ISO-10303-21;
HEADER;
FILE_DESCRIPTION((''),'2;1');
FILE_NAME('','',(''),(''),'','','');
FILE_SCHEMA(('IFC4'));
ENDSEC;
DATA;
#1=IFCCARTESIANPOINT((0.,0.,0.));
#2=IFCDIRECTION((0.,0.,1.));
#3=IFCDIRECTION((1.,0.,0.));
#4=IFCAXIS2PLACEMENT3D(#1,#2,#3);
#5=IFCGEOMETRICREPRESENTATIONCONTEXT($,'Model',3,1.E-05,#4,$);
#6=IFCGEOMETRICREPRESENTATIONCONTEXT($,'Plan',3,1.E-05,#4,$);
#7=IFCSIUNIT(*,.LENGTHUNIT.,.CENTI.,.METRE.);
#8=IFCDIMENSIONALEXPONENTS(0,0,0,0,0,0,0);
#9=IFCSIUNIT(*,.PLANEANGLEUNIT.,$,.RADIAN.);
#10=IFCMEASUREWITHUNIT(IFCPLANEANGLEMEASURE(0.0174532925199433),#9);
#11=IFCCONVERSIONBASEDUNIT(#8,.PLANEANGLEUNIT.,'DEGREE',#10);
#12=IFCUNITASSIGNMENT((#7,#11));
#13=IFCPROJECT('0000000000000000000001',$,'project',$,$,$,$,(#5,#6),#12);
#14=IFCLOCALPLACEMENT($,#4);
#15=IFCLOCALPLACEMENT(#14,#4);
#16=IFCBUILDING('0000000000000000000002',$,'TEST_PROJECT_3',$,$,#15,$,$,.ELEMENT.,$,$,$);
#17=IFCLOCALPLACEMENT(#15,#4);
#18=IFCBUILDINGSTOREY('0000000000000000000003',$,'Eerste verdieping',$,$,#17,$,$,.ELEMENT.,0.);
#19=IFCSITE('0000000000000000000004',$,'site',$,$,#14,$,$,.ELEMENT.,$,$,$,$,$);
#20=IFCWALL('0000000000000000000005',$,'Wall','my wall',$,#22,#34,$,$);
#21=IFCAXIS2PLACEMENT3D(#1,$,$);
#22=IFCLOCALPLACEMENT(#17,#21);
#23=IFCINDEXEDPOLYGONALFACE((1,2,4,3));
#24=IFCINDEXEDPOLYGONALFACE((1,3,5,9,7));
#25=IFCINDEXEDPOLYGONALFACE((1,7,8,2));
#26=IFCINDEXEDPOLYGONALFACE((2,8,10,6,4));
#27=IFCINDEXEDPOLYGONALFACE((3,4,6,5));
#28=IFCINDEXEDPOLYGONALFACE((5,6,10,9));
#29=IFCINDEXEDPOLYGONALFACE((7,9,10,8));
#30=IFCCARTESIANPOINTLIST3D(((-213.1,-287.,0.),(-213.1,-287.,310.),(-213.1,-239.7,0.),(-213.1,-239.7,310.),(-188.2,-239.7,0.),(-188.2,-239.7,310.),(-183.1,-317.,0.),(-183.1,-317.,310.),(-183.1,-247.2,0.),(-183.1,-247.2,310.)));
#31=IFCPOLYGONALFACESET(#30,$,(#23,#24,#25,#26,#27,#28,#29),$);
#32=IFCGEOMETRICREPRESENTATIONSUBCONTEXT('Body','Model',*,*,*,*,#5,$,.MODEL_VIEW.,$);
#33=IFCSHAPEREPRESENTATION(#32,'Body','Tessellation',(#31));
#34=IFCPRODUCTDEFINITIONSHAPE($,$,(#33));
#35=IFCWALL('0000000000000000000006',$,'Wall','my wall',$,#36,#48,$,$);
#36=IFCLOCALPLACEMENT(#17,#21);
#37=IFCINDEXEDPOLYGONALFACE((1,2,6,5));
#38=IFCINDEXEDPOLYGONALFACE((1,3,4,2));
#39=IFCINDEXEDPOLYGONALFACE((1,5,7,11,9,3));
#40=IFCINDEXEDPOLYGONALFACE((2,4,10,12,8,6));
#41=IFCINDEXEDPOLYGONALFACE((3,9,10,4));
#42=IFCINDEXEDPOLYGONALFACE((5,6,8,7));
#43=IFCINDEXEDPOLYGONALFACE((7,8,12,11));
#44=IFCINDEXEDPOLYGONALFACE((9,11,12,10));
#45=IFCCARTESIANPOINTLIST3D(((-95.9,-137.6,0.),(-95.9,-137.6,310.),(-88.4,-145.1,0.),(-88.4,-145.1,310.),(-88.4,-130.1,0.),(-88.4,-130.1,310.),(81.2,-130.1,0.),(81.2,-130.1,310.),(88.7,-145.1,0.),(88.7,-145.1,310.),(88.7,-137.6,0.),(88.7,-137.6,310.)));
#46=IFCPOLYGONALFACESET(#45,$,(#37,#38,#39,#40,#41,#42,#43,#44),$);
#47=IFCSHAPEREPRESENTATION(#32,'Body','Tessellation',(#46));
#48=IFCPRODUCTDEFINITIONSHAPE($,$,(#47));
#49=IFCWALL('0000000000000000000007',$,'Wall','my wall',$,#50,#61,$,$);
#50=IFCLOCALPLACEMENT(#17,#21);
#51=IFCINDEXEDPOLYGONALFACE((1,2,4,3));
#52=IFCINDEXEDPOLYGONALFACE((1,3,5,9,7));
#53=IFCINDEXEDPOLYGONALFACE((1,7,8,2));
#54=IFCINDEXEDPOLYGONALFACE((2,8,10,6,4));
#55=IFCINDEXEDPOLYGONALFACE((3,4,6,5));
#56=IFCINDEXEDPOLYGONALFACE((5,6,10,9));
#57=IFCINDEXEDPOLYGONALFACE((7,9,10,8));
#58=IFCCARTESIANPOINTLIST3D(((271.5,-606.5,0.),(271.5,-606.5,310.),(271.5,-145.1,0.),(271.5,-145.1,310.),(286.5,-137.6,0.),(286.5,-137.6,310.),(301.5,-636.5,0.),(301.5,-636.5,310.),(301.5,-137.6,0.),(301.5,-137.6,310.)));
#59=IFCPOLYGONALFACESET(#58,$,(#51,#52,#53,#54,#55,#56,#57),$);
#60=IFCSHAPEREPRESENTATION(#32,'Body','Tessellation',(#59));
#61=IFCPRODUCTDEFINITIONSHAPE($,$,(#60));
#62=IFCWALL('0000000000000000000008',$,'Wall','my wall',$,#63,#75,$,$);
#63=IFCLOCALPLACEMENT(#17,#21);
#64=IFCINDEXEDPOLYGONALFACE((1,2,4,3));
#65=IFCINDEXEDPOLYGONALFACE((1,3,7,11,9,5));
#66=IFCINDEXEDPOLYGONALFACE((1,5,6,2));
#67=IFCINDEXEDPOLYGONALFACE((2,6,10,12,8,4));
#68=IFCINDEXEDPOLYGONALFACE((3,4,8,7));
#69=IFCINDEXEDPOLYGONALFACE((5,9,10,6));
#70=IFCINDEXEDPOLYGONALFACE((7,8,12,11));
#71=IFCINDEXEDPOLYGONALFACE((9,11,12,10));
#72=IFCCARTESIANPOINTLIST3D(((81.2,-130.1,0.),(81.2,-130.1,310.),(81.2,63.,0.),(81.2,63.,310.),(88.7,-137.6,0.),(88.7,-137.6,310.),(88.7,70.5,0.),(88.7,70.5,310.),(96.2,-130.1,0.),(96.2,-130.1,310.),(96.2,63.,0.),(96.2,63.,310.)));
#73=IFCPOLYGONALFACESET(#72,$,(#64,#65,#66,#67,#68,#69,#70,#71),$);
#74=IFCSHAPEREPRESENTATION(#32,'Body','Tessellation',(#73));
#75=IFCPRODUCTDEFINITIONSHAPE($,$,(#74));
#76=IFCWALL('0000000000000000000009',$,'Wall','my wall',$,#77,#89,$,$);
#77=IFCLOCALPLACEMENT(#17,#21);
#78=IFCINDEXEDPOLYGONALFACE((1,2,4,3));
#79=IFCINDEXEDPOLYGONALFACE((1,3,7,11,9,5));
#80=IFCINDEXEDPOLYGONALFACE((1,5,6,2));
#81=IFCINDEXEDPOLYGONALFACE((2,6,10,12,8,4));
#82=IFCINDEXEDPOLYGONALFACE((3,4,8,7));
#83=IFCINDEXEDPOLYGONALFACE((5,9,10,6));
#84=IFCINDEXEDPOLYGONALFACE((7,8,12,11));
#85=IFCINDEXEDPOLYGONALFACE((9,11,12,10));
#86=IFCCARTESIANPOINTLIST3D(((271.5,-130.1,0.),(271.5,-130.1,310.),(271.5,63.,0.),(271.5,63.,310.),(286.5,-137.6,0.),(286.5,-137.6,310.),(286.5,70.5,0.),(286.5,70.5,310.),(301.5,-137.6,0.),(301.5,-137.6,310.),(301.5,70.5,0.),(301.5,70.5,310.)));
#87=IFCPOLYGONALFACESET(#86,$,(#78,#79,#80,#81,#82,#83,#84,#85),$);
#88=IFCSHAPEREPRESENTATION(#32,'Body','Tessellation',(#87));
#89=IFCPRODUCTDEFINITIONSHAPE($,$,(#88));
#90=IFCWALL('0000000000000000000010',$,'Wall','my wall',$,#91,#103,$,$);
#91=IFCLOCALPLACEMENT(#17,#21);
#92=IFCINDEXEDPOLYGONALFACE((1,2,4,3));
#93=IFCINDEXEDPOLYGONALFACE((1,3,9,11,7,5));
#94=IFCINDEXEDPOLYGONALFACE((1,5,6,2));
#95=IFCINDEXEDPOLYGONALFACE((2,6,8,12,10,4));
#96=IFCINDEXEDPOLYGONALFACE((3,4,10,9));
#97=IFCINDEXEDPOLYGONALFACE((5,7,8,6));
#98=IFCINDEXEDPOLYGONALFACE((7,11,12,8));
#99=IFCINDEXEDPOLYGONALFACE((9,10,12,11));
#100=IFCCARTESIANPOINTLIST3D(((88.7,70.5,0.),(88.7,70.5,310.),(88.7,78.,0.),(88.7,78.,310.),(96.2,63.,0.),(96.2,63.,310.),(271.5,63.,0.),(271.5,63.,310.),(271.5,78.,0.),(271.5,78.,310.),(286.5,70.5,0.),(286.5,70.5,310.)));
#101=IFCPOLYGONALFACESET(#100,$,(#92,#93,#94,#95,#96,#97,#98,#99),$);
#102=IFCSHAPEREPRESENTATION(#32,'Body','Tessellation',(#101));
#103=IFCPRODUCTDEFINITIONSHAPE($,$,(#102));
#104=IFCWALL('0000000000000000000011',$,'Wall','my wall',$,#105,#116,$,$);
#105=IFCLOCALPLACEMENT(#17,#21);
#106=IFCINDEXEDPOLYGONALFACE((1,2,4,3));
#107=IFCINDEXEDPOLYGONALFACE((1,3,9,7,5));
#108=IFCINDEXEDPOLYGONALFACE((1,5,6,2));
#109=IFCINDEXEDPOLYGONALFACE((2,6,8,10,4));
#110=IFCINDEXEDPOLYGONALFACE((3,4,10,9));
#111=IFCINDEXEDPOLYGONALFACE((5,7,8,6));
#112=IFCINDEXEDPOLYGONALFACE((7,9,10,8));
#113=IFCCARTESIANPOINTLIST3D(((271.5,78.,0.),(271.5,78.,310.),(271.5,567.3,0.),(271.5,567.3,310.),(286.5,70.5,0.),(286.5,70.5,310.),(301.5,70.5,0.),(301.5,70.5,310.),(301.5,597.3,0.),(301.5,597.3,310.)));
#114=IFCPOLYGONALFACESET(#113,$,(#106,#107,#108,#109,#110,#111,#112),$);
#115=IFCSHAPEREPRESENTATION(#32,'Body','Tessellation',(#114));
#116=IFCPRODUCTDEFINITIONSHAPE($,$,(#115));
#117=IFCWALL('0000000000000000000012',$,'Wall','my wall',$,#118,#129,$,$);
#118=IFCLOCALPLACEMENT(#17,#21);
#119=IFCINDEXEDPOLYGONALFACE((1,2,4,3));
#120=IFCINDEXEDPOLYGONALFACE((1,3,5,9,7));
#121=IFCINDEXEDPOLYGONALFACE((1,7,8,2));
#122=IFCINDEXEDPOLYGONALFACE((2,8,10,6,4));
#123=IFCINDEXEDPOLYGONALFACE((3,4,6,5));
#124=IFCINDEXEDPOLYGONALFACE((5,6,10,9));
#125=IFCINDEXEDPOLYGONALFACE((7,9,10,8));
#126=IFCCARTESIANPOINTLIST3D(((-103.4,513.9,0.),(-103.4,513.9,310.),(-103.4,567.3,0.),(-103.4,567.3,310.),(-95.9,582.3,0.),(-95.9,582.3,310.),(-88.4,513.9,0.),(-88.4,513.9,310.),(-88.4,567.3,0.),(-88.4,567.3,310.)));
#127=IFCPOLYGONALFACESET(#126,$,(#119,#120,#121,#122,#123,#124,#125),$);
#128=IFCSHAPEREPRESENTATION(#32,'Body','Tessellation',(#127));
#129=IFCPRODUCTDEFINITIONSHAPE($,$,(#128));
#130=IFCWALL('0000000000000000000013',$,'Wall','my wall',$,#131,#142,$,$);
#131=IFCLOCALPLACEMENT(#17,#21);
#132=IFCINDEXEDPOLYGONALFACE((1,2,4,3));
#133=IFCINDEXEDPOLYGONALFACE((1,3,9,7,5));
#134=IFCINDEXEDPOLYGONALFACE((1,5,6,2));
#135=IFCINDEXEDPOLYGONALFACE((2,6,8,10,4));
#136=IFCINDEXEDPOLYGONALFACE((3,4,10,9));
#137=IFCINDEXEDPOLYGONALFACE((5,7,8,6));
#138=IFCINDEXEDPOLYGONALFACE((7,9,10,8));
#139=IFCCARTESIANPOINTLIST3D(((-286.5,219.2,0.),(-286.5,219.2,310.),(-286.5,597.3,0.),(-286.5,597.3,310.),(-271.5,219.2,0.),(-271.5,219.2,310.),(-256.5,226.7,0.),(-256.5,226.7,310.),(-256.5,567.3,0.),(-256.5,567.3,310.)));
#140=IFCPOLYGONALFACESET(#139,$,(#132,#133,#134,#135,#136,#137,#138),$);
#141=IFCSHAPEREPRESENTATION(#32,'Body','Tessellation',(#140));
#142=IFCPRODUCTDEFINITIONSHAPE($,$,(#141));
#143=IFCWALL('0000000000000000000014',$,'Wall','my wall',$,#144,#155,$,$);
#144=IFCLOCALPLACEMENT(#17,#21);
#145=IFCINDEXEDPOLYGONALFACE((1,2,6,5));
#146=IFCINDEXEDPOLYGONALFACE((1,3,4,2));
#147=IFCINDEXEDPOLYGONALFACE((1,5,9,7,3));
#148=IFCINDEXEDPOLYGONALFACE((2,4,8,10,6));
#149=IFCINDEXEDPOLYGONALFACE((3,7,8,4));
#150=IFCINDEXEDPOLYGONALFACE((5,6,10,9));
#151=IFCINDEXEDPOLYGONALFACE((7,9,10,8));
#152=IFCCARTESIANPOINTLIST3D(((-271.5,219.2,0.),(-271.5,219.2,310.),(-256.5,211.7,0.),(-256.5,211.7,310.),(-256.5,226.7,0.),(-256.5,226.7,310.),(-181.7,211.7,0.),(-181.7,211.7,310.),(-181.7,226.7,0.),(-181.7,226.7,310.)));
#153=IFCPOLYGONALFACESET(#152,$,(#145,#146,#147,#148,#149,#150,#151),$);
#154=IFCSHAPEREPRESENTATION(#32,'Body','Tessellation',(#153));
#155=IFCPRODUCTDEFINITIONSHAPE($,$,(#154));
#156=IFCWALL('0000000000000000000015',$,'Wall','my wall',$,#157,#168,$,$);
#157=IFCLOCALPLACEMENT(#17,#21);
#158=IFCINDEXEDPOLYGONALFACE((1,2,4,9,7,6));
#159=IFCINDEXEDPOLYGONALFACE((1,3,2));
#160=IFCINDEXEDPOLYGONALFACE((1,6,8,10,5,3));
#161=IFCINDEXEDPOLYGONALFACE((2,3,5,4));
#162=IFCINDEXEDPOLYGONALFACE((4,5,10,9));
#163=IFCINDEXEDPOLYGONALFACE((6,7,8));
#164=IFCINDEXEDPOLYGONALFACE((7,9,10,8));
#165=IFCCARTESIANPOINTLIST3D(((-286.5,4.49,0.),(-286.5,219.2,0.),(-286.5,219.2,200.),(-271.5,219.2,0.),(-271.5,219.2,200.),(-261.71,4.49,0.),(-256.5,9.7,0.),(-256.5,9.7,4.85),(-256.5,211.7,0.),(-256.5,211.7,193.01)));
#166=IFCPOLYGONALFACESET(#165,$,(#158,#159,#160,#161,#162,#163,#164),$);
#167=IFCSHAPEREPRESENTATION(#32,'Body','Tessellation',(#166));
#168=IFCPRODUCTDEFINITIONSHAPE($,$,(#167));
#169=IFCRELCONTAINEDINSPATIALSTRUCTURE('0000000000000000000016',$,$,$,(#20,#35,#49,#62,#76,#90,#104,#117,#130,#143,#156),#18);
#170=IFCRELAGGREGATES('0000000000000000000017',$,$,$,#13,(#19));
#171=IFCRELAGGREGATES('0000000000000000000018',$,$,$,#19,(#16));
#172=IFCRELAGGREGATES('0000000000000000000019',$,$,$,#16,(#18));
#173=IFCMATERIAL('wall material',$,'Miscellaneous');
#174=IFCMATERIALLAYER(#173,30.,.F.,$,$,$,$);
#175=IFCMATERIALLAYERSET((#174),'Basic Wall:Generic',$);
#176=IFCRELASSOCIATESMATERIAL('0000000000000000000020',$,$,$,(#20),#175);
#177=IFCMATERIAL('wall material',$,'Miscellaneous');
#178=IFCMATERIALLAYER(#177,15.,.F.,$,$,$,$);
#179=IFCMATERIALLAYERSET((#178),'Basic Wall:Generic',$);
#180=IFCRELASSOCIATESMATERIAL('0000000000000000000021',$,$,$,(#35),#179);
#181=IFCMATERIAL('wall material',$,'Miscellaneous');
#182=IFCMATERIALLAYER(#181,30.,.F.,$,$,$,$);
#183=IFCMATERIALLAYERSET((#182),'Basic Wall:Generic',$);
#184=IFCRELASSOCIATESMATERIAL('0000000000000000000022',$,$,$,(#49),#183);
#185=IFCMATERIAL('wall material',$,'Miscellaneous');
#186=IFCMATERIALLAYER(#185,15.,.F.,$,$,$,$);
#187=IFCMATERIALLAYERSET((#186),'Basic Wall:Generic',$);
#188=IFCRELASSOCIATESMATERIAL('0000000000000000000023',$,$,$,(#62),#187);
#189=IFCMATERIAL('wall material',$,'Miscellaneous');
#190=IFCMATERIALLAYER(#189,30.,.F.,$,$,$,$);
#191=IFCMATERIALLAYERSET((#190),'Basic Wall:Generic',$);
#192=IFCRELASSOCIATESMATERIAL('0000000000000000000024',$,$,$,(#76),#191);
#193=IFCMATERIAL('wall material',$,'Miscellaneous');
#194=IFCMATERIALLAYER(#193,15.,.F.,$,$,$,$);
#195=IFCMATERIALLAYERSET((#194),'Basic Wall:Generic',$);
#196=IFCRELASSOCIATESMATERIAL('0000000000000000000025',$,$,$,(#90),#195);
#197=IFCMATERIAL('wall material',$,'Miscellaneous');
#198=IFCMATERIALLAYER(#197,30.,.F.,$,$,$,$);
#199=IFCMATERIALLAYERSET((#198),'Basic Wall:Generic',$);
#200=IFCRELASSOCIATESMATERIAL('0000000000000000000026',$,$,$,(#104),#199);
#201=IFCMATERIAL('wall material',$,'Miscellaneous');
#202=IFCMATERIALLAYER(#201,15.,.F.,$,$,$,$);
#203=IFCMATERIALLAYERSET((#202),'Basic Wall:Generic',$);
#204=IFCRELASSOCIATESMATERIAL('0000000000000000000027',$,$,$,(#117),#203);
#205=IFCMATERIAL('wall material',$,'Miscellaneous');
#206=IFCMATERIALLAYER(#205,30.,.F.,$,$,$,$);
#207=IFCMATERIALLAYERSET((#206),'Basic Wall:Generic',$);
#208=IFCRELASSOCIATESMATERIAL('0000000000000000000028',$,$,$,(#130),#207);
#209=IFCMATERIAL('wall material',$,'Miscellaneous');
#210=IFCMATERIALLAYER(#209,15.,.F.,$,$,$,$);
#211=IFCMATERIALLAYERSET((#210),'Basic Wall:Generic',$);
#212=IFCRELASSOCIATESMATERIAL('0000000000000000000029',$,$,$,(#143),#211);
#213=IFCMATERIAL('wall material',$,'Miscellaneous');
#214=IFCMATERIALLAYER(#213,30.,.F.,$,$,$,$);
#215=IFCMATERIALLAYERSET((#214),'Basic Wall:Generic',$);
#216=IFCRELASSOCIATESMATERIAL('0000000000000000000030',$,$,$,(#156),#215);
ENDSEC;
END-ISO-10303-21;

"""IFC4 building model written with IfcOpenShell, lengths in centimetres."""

from ifc_helpers import new_model, entity, si_unit, converted_unit, frame, origin_with_axes, place, context, subcontext, project, spatial, polyline, outline, extrude, clip, bounded_halfspace, material, layer, layer_set, layer_usage, element, save


model = new_model("IFC4")

# Units and contexts
model_context = context("Model", 3, precision=1e-05, world=origin_with_axes())
plan_context = context("Plan", 3, precision=1e-05, world=origin_with_axes())
body_context = subcontext(model_context, "Body", "Model", "MODEL_VIEW")
ifc_project = project(units=[si_unit("LENGTHUNIT", "METRE", prefix="CENTI"), converted_unit("PLANEANGLEUNIT", "DEGREE", entity("IfcPlaneAngleMeasure", 0.0174532925199433), si_unit("PLANEANGLEUNIT", "RADIAN"), dimensions=[0, 0, 0, 0, 0, 0, 0])], contexts=[model_context, plan_context])

# Site, building, storey
site_placement = place(None, origin_with_axes())
site = spatial("IfcSite", under=ifc_project, at=site_placement, Name="site", CompositionType="ELEMENT")
building_placement = place(site_placement, origin_with_axes())
building = spatial("IfcBuilding", under=site, at=building_placement, Name="TEST_PROJECT_3", CompositionType="ELEMENT")
storey_placement = place(building_placement, origin_with_axes())
storey = spatial("IfcBuildingStorey", under=building, at=storey_placement, Name="Eerste verdieping", CompositionType="ELEMENT", Elevation=0.0)

# Walls
ifc_material_1 = material(Name="wall material", Category="Miscellaneous")
ifc_layer_1 = layer(ifc_material_1, 30.0, ventilated=False)
ifc_layer_set_1 = layer_set([ifc_layer_1], Name="Basic Wall:Generic")
ifc_layer_usage_1 = layer_usage(ifc_layer_set_1, "AXIS3", "NEGATIVE", 0.0)
wall_1_placement = place(storey_placement, origin_with_axes())
element("IfcWall", 1, at=wall_1_placement, inside=storey, material=ifc_layer_usage_1, Name="Wall", Description="my wall", context=body_context, shape_type="SweptSolid", body=[
    extrude(outline(polyline([(-213.1, -287.0, 0.0), (-213.1, -239.7, 0.0), (-188.2, -239.7, 0.0), (-183.1, -247.2, 0.0), (-183.1, -317.0, 0.0), (-213.1, -287.0, 0.0)])), origin_with_axes(), (0.0, 0.0, 1.0), 310.0),
])
ifc_material_2 = material(Name="wall material", Category="Miscellaneous")
ifc_layer_2 = layer(ifc_material_2, 15.0, ventilated=False)
ifc_layer_set_2 = layer_set([ifc_layer_2], Name="Basic Wall:Generic")
ifc_layer_usage_2 = layer_usage(ifc_layer_set_2, "AXIS3", "NEGATIVE", 0.0)
wall_2_placement = place(storey_placement, origin_with_axes())
element("IfcWall", 2, at=wall_2_placement, inside=storey, material=ifc_layer_usage_2, Name="Wall", Description="my wall", context=body_context, shape_type="SweptSolid", body=[
    extrude(outline(polyline([(-88.4, -145.1, 0.0), (-95.9, -137.6, 0.0), (-88.4, -130.1, 0.0), (81.2, -130.1, 0.0), (88.7, -137.6, 0.0), (88.7, -145.1, 0.0), (-88.4, -145.1, 0.0)])), origin_with_axes(), (0.0, 0.0, 1.0), 310.0),
])
ifc_material_3 = material(Name="wall material", Category="Miscellaneous")
ifc_layer_3 = layer(ifc_material_3, 30.0, ventilated=False)
ifc_layer_set_3 = layer_set([ifc_layer_3], Name="Basic Wall:Generic")
ifc_layer_usage_3 = layer_usage(ifc_layer_set_3, "AXIS3", "NEGATIVE", 0.0)
wall_3_placement = place(storey_placement, origin_with_axes())
element("IfcWall", 3, at=wall_3_placement, inside=storey, material=ifc_layer_usage_3, Name="Wall", Description="my wall", context=body_context, shape_type="SweptSolid", body=[
    extrude(outline(polyline([(271.5, -606.5, 0.0), (271.5, -145.1, 0.0), (286.5, -137.6, 0.0), (301.5, -137.6, 0.0), (301.5, -636.5, 0.0), (271.5, -606.5, 0.0)])), origin_with_axes(), (0.0, 0.0, 1.0), 310.0),
])

# Wall
ifc_material_4 = material(Name="wall material", Category="Miscellaneous")
ifc_layer_4 = layer(ifc_material_4, 15.0, ventilated=False)
ifc_layer_set_4 = layer_set([ifc_layer_4], Name="Basic Wall:Generic")
ifc_layer_usage_4 = layer_usage(ifc_layer_set_4, "AXIS3", "NEGATIVE", 0.0)
wall_4_placement = place(storey_placement, origin_with_axes())
element("IfcWall", 4, at=wall_4_placement, inside=storey, material=ifc_layer_usage_4, Name="Wall", Description="my wall", context=body_context, shape_type="SweptSolid", body=[
    extrude(outline(polyline([(81.2, -130.1, 0.0), (81.2, 63.0, 0.0), (88.7, 70.5, 0.0), (96.2, 63.0, 0.0), (96.2, -130.1, 0.0), (88.7, -137.6, 0.0), (81.2, -130.1, 0.0)])), origin_with_axes(), (0.0, 0.0, 1.0), 310.0),
])

# Walls
ifc_material_5 = material(Name="wall material", Category="Miscellaneous")
ifc_layer_5 = layer(ifc_material_5, 30.0, ventilated=False)
ifc_layer_set_5 = layer_set([ifc_layer_5], Name="Basic Wall:Generic")
ifc_layer_usage_5 = layer_usage(ifc_layer_set_5, "AXIS3", "NEGATIVE", 0.0)
wall_5_placement = place(storey_placement, origin_with_axes())
element("IfcWall", 5, at=wall_5_placement, inside=storey, material=ifc_layer_usage_5, Name="Wall", Description="my wall", context=body_context, shape_type="SweptSolid", body=[
    extrude(outline(polyline([(271.5, -130.1, 0.0), (271.5, 63.0, 0.0), (286.5, 70.5, 0.0), (301.5, 70.5, 0.0), (301.5, -137.6, 0.0), (286.5, -137.6, 0.0), (271.5, -130.1, 0.0)])), origin_with_axes(), (0.0, 0.0, 1.0), 310.0),
])
ifc_material_6 = material(Name="wall material", Category="Miscellaneous")
ifc_layer_6 = layer(ifc_material_6, 15.0, ventilated=False)
ifc_layer_set_6 = layer_set([ifc_layer_6], Name="Basic Wall:Generic")
ifc_layer_usage_6 = layer_usage(ifc_layer_set_6, "AXIS3", "NEGATIVE", 0.0)
wall_6_placement = place(storey_placement, origin_with_axes())
element("IfcWall", 6, at=wall_6_placement, inside=storey, material=ifc_layer_usage_6, Name="Wall", Description="my wall", context=body_context, shape_type="SweptSolid", body=[
    extrude(outline(polyline([(96.2, 63.0, 0.0), (88.7, 70.5, 0.0), (88.7, 78.0, 0.0), (271.5, 78.0, 0.0), (286.5, 70.5, 0.0), (271.5, 63.0, 0.0), (96.2, 63.0, 0.0)])), origin_with_axes(), (0.0, 0.0, 1.0), 310.0),
])
ifc_material_7 = material(Name="wall material", Category="Miscellaneous")
ifc_layer_7 = layer(ifc_material_7, 30.0, ventilated=False)
ifc_layer_set_7 = layer_set([ifc_layer_7], Name="Basic Wall:Generic")
ifc_layer_usage_7 = layer_usage(ifc_layer_set_7, "AXIS3", "NEGATIVE", 0.0)
wall_7_placement = place(storey_placement, origin_with_axes())
element("IfcWall", 7, at=wall_7_placement, inside=storey, material=ifc_layer_usage_7, Name="Wall", Description="my wall", context=body_context, shape_type="SweptSolid", body=[
    extrude(outline(polyline([(271.5, 78.0, 0.0), (271.5, 567.3, 0.0), (301.5, 597.3, 0.0), (301.5, 70.5, 0.0), (286.5, 70.5, 0.0), (271.5, 78.0, 0.0)])), origin_with_axes(), (0.0, 0.0, 1.0), 310.0),
])

# Wall
ifc_material_8 = material(Name="wall material", Category="Miscellaneous")
ifc_layer_8 = layer(ifc_material_8, 15.0, ventilated=False)
ifc_layer_set_8 = layer_set([ifc_layer_8], Name="Basic Wall:Generic")
ifc_layer_usage_8 = layer_usage(ifc_layer_set_8, "AXIS3", "NEGATIVE", 0.0)
wall_8_placement = place(storey_placement, origin_with_axes())
element("IfcWall", 8, at=wall_8_placement, inside=storey, material=ifc_layer_usage_8, Name="Wall", Description="my wall", context=body_context, shape_type="SweptSolid", body=[
    extrude(outline(polyline([(-103.4, 513.9, 0.0), (-103.4, 567.3, 0.0), (-95.9, 582.3, 0.0), (-88.4, 567.3, 0.0), (-88.4, 513.9, 0.0), (-103.4, 513.9, 0.0)])), origin_with_axes(), (0.0, 0.0, 1.0), 310.0),
])

# Walls
ifc_material_9 = material(Name="wall material", Category="Miscellaneous")
ifc_layer_9 = layer(ifc_material_9, 30.0, ventilated=False)
ifc_layer_set_9 = layer_set([ifc_layer_9], Name="Basic Wall:Generic")
ifc_layer_usage_9 = layer_usage(ifc_layer_set_9, "AXIS3", "NEGATIVE", 0.0)
wall_9_placement = place(storey_placement, origin_with_axes())
element("IfcWall", 9, at=wall_9_placement, inside=storey, material=ifc_layer_usage_9, Name="Wall", Description="my wall", context=body_context, shape_type="SweptSolid", body=[
    extrude(outline(polyline([(-286.5, 219.2, 0.0), (-286.5, 597.3, 0.0), (-256.5, 567.3, 0.0), (-256.5, 226.7, 0.0), (-271.5, 219.2, 0.0), (-286.5, 219.2, 0.0)])), origin_with_axes(), (0.0, 0.0, 1.0), 310.0),
])
ifc_material_10 = material(Name="wall material", Category="Miscellaneous")
ifc_layer_10 = layer(ifc_material_10, 15.0, ventilated=False)
ifc_layer_set_10 = layer_set([ifc_layer_10], Name="Basic Wall:Generic")
ifc_layer_usage_10 = layer_usage(ifc_layer_set_10, "AXIS3", "NEGATIVE", 0.0)
wall_10_placement = place(storey_placement, origin_with_axes())
element("IfcWall", 10, at=wall_10_placement, inside=storey, material=ifc_layer_usage_10, Name="Wall", Description="my wall", context=body_context, shape_type="SweptSolid", body=[
    extrude(outline(polyline([(-256.5, 211.7, 0.0), (-271.5, 219.2, 0.0), (-256.5, 226.7, 0.0), (-181.7, 226.7, 0.0), (-181.7, 211.7, 0.0), (-256.5, 211.7, 0.0)])), origin_with_axes(), (0.0, 0.0, 1.0), 310.0),
])
ifc_material_11 = material(Name="wall material", Category="Miscellaneous")
ifc_layer_11 = layer(ifc_material_11, 30.0, ventilated=False)
ifc_layer_set_11 = layer_set([ifc_layer_11], Name="Basic Wall:Generic")
ifc_layer_usage_11 = layer_usage(ifc_layer_set_11, "AXIS3", "NEGATIVE", 0.0)
wall_11_placement = place(storey_placement, origin_with_axes())
element("IfcWall", 11, at=wall_11_placement, inside=storey, material=ifc_layer_usage_11, Name="Wall", Description="my wall", context=body_context, shape_type="SweptSolid", body=[
    clip(extrude(outline(polyline([(-286.5, -20.3, 0.0), (-286.5, 219.2, 0.0), (-271.5, 219.2, 0.0), (-256.5, 211.7, 0.0), (-256.5, 9.7, 0.0), (-286.5, -20.3, 0.0)])), origin_with_axes(), (0.0, 0.0, 1.0), 200.0), bounded_halfspace(frame((-271.5, 219.2, 200.0), z_axis=(0.0, -0.68, 0.73), x_axis=(0.0, -0.731554, -0.681784)), False, origin_with_axes(), polyline([(-286.5, -20.3, 0.0), (-286.5, 219.2, 0.0), (-271.5, 219.2, 0.0), (-256.5, 211.7, 0.0), (-256.5, 9.7, 0.0), (-286.5, -20.3, 0.0)]))),
])

save(model, "model.ifc")
